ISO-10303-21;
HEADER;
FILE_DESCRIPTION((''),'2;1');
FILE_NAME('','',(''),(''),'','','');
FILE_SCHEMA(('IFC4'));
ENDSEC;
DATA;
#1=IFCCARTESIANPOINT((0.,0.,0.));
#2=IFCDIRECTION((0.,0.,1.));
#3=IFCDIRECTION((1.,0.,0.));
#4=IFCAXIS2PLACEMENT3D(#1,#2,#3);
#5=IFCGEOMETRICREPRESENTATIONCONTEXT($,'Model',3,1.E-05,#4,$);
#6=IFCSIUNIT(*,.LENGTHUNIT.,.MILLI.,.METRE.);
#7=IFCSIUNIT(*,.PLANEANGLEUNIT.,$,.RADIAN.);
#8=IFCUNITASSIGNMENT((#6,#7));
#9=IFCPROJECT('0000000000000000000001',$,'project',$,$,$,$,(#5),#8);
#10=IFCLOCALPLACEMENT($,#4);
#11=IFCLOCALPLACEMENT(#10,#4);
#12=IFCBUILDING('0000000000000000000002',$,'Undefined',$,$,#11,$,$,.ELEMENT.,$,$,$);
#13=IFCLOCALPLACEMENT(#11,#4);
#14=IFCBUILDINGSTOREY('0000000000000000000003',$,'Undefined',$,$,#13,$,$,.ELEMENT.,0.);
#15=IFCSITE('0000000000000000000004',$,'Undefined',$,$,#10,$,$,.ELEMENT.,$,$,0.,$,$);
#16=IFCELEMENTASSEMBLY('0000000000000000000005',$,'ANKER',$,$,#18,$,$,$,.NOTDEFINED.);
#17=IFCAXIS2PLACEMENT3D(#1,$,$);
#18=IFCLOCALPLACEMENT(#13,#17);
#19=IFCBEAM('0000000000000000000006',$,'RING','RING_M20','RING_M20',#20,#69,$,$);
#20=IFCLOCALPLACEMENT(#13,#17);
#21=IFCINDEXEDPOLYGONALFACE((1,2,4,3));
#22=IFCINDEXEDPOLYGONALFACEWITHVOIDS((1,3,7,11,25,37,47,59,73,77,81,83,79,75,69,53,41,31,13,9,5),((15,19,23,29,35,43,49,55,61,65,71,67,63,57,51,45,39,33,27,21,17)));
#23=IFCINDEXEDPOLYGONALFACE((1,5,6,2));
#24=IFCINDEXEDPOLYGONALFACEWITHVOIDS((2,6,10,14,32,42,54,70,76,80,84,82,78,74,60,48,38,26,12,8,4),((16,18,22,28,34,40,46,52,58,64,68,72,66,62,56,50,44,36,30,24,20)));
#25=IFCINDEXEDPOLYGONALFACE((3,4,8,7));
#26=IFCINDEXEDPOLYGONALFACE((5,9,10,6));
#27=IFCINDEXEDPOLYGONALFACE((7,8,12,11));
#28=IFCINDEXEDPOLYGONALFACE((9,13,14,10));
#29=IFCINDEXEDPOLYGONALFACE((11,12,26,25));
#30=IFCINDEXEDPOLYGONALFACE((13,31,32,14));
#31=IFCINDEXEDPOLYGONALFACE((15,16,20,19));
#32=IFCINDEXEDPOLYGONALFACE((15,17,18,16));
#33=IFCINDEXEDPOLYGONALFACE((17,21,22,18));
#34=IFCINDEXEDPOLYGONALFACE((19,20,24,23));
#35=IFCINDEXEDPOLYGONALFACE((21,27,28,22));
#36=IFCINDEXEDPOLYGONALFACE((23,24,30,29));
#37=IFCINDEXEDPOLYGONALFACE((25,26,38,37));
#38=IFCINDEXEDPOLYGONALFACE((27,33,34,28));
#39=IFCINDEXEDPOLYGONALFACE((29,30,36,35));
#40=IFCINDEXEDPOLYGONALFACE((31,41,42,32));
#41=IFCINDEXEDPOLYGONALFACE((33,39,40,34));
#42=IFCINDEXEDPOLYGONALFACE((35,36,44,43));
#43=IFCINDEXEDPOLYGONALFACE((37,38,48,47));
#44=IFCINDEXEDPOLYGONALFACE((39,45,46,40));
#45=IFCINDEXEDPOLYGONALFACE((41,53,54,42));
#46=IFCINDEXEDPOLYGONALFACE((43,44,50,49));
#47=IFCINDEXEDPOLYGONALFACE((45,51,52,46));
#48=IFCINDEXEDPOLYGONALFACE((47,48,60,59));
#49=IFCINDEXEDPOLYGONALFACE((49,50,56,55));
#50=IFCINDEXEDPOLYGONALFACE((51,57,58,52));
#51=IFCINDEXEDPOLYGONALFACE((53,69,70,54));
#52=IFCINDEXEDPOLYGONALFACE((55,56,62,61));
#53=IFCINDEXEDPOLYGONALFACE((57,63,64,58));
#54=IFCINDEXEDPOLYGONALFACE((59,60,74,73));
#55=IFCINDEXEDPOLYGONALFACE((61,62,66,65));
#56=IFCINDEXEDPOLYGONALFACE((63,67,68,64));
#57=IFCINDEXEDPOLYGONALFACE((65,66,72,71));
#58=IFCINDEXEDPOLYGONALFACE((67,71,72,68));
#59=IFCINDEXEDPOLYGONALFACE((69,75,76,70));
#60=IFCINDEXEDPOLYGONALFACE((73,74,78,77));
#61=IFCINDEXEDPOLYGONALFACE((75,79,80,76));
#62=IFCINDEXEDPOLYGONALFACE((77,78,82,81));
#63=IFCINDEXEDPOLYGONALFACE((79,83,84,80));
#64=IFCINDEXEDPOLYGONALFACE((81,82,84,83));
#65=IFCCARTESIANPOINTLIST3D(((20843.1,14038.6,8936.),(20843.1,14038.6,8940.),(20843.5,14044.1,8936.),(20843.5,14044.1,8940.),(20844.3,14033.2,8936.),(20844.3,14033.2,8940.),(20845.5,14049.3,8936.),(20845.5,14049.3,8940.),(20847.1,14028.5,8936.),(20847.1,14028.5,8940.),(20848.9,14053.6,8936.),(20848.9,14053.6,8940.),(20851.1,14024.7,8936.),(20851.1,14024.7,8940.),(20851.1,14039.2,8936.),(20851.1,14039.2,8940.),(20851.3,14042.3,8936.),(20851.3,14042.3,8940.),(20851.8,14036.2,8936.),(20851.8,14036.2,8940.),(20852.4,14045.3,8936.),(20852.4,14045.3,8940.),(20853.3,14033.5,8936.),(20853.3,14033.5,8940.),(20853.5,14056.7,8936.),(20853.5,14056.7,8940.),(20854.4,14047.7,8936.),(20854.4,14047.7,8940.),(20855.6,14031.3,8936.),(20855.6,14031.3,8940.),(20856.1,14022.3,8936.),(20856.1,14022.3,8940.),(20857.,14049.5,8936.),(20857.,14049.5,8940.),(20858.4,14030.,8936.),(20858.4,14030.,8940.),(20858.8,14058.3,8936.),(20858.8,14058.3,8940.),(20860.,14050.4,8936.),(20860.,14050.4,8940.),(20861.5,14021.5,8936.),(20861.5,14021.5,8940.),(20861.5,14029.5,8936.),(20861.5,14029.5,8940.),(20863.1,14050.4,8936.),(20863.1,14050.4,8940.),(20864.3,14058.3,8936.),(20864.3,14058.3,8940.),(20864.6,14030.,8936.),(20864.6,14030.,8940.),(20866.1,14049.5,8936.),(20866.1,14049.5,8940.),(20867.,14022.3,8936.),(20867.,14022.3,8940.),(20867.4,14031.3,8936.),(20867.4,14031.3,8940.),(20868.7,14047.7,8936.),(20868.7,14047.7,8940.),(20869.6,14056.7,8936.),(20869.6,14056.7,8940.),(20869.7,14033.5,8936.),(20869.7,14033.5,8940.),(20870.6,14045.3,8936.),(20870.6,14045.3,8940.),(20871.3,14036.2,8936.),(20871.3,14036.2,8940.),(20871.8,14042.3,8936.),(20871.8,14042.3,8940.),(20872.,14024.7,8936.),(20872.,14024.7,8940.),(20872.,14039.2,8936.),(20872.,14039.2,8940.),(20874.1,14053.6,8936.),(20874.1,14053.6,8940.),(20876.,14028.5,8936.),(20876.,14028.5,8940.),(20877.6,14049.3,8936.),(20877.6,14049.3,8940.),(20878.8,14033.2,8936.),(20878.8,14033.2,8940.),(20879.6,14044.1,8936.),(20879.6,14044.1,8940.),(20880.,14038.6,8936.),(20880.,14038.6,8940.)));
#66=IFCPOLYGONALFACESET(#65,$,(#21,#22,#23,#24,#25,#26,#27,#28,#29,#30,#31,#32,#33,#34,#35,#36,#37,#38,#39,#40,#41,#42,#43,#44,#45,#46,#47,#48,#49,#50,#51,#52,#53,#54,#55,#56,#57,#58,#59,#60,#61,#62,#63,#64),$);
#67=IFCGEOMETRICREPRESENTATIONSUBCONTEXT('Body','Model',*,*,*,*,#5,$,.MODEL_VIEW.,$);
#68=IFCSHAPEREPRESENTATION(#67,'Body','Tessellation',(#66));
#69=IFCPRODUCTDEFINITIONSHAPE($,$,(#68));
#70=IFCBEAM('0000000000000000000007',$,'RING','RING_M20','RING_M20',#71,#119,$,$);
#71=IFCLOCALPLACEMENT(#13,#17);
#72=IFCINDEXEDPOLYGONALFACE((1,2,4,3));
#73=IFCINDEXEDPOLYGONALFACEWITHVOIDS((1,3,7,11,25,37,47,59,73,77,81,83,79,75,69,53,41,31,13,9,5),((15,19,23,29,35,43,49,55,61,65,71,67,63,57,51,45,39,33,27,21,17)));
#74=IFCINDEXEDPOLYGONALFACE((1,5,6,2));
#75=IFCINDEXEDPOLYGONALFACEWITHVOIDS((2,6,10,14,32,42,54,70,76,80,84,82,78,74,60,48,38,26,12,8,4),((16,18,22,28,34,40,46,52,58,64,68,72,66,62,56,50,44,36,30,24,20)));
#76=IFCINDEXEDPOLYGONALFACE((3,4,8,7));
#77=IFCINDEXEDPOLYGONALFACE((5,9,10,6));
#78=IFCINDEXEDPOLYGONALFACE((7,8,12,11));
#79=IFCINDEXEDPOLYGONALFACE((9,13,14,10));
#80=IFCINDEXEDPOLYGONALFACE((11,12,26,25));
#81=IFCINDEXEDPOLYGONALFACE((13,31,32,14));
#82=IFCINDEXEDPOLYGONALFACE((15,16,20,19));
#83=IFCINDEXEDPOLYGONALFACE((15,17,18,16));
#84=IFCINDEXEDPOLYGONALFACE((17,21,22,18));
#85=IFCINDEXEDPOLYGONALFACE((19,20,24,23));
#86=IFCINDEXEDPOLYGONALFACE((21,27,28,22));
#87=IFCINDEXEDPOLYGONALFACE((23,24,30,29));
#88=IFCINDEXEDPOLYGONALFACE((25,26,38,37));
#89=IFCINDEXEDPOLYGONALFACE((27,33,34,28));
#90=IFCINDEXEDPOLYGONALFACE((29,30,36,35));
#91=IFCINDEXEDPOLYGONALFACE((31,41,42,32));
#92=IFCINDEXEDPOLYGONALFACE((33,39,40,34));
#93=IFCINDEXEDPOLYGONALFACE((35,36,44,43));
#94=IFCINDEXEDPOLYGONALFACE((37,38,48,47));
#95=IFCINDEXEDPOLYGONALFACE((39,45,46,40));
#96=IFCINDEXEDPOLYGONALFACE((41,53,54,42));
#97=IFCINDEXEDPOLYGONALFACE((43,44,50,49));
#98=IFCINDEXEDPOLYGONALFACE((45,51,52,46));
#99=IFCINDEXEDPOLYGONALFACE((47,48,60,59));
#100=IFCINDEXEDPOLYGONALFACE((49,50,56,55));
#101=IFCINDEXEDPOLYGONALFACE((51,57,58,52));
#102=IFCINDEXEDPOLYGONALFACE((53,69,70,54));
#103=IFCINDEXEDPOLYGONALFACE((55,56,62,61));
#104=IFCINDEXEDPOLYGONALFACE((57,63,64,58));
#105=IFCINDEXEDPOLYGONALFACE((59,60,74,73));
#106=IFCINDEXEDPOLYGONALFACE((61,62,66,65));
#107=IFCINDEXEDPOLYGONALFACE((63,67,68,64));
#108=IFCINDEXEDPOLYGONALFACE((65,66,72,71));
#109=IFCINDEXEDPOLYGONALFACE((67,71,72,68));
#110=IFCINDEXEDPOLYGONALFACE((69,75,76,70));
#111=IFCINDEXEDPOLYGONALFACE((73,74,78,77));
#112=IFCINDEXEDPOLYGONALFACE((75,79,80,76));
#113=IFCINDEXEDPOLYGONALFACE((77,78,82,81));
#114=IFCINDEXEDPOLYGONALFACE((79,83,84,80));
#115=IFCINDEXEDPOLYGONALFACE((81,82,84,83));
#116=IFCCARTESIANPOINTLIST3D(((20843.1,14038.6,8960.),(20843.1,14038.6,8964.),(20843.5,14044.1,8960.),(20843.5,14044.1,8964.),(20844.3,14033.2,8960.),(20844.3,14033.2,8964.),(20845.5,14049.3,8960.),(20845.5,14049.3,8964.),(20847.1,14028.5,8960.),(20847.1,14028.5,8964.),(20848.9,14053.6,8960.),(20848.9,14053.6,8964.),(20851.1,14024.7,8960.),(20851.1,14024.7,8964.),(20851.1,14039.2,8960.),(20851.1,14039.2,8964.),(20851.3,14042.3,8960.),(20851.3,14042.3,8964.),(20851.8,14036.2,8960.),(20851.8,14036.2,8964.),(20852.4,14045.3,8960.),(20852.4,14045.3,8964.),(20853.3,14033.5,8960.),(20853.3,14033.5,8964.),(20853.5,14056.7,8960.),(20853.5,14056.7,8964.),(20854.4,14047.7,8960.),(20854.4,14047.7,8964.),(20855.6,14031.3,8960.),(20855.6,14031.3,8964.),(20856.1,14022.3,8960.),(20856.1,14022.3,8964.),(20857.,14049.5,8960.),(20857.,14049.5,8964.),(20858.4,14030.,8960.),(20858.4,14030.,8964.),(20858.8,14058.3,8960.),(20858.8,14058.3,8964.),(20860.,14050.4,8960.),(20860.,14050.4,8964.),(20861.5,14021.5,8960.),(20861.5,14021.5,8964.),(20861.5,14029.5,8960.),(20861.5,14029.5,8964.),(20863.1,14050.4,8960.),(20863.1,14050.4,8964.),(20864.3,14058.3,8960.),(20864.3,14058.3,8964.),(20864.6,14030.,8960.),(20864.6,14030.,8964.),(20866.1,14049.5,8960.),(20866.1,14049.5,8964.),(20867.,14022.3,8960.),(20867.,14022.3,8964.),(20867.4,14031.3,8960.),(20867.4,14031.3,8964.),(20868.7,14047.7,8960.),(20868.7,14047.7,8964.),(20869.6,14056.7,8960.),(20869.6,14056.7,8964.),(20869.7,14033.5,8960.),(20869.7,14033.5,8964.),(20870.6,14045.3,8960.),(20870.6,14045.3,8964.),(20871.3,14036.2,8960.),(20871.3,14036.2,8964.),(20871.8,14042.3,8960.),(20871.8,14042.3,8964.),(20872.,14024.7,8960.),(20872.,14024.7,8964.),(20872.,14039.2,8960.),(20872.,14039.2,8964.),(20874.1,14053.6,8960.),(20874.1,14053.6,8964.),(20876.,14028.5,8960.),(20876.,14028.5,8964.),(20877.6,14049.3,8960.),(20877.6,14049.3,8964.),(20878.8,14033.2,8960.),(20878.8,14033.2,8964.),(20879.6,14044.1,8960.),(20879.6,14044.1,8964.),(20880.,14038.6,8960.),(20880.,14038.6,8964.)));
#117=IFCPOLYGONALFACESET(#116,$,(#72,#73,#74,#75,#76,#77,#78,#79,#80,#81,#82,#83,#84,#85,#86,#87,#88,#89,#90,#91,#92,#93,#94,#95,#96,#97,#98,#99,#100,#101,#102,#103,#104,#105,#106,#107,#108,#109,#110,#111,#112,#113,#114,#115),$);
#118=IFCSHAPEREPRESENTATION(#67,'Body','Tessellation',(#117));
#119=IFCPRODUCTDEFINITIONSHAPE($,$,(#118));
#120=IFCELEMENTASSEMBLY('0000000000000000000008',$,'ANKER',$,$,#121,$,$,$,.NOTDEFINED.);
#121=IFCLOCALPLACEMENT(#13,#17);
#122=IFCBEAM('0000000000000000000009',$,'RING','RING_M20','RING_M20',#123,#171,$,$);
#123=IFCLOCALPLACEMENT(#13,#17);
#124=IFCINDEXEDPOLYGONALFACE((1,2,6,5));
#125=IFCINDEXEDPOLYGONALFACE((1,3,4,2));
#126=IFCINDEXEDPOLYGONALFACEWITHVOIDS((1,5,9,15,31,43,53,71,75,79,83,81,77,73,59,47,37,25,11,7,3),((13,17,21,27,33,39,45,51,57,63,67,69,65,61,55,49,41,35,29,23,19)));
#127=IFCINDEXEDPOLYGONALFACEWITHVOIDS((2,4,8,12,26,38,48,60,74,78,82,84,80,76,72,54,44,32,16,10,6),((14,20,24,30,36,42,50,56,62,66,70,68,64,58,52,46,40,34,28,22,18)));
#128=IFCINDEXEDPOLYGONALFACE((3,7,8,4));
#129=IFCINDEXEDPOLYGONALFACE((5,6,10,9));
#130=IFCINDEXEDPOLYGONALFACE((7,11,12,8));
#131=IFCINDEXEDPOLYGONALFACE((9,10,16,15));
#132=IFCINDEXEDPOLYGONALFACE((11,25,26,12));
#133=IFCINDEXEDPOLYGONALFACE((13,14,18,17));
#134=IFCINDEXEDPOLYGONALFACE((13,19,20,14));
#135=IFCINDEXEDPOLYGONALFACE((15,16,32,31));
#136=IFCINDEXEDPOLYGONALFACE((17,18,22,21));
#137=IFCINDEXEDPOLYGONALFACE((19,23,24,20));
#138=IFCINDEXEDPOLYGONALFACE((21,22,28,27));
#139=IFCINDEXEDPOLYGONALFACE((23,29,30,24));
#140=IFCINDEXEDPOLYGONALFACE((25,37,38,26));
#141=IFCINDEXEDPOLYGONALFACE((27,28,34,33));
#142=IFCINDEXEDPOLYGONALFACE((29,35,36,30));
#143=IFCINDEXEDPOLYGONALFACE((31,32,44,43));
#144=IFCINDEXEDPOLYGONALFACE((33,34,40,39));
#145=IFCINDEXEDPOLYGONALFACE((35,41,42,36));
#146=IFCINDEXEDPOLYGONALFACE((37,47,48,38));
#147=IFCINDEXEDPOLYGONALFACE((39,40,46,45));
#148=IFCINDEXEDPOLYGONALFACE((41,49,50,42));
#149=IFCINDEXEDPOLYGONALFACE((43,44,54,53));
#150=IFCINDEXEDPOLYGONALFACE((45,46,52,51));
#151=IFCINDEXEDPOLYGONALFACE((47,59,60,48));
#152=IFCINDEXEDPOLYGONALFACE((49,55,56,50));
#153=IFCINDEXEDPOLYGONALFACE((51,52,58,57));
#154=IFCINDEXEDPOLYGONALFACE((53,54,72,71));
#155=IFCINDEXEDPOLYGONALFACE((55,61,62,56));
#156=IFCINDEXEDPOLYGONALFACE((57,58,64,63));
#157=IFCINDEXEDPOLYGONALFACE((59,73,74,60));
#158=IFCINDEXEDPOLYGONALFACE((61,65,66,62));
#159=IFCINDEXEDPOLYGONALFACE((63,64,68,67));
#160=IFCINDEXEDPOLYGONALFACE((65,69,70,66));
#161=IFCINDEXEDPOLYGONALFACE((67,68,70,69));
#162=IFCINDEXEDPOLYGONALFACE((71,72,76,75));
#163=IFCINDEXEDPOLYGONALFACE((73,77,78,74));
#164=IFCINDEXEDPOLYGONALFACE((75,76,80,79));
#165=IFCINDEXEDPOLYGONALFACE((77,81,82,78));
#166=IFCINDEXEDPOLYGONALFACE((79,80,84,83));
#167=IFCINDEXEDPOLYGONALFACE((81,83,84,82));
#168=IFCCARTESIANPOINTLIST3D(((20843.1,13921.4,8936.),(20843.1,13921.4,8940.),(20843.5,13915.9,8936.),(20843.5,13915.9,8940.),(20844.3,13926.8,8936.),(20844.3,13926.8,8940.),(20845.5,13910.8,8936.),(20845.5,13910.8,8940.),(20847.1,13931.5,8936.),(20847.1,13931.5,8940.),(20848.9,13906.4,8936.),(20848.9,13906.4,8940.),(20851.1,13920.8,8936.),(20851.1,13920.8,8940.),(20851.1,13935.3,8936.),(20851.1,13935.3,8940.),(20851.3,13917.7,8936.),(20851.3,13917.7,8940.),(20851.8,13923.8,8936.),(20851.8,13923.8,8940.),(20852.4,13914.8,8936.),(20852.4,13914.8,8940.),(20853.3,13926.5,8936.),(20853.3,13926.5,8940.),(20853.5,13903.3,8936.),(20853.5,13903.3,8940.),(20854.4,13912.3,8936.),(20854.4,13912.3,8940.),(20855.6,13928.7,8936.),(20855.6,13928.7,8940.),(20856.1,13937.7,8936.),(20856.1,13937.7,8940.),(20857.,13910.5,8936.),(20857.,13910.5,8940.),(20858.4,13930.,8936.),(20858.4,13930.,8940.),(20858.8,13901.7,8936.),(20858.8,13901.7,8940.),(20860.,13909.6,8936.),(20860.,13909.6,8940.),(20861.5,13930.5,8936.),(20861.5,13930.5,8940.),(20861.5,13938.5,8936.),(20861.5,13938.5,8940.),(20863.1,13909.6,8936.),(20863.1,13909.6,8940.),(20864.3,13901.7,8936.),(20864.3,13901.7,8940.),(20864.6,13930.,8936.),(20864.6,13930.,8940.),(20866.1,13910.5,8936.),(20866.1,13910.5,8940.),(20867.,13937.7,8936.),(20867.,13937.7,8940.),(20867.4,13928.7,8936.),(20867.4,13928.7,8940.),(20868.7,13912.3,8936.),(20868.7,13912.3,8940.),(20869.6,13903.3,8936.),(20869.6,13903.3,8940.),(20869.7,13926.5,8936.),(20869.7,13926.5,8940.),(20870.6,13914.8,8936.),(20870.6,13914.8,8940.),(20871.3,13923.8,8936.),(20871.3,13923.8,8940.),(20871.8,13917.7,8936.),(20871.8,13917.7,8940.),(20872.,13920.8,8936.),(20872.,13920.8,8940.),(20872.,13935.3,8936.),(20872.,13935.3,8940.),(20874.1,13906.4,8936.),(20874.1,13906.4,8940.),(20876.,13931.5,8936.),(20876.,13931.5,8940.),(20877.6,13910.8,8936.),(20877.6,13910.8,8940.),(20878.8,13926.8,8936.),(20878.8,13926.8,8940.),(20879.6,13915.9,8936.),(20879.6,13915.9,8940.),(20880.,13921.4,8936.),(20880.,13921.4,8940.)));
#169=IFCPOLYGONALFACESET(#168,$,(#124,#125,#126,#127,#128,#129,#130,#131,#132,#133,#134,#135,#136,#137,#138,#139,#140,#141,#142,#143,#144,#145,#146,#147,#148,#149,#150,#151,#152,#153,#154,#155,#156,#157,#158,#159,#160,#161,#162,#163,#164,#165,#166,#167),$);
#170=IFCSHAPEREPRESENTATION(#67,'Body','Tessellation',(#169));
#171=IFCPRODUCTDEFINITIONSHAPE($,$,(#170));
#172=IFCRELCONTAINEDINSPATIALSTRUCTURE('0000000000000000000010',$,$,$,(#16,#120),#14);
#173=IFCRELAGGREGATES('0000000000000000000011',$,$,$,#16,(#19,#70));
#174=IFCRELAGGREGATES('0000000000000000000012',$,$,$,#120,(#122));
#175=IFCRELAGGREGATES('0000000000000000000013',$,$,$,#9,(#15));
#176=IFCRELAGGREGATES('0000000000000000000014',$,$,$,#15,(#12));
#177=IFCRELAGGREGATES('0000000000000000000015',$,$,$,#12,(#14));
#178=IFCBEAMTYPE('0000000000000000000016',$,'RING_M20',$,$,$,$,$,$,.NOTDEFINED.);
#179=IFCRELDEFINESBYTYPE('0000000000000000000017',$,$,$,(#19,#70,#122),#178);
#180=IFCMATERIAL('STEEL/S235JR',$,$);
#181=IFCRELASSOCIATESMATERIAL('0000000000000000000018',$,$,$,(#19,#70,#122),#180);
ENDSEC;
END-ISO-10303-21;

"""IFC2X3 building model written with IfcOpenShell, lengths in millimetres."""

from ifc_helpers import new_model, si_unit, frame, origin_with_axes, origin_2d_with_axis, place, context, subcontext, project, spatial, hollow_circle, extrude, material, type_object, element, aggregate, save


model = new_model("IFC2X3")

# Units and contexts
model_context = context("Model", 3, precision=1e-05, world=origin_with_axes())
body_context = subcontext(model_context, "Body", "Model", "MODEL_VIEW")
ifc_project = project(units=[si_unit("LENGTHUNIT", "METRE", prefix="MILLI"), si_unit("PLANEANGLEUNIT", "RADIAN")], contexts=[model_context])

# Site, building, storey
site_placement = place(None, origin_with_axes())
site = spatial("IfcSite", under=ifc_project, at=site_placement, Name="Undefined", CompositionType="ELEMENT", RefElevation=0.0)
building_placement = place(site_placement, origin_with_axes())
building = spatial("IfcBuilding", under=site, at=building_placement, Name="Undefined", CompositionType="ELEMENT")
storey_placement = place(building_placement, origin_with_axes())
storey = spatial("IfcBuildingStorey", under=building, at=storey_placement, Name="Undefined", CompositionType="ELEMENT", Elevation=0.0)

# Shared definitions
ifc_material = material(Name="STEEL/S235JR")

# Element assemblies, beams
beam_type_1 = type_object("IfcBeamType", Name="RING_M20", PredefinedType="NOTDEFINED")
assembly_1_placement = place(storey_placement, frame((20861.5, 14040.0, 9010.0), z_axis=(0.0, 1.0, 0.0), x_axis=(0.0, 0.0, -1.0)))
assembly_1 = element("IfcElementAssembly", 1, at=assembly_1_placement, inside=storey, Name="ANKER", PredefinedType="NOTDEFINED")
beam_1_placement = place(storey_placement, frame((20861.5, 14040.0, 8940.0), z_axis=(1.0, 0.0, 0.0), x_axis=(0.0, 0.0, -1.0)))
beam_1 = element("IfcBeam", 2, at=beam_1_placement, type_object=beam_type_1, material=ifc_material, Name="RING", Description="RING_M20", ObjectType="RING_M20", context=body_context, shape_type="SweptSolid", body=[
    extrude(hollow_circle(Radius=18.5, WallThickness=8.0, at=origin_2d_with_axis()), frame((4.0, 0.0, 0.0), z_axis=(-1.0, 0.0, 0.0), x_axis=(0.0, -1.0, 0.0)), (0.0, 0.0, 1.0), 4.0),
])
beam_2_placement = place(storey_placement, frame((20861.5, 14040.0, 8964.0), z_axis=(1.0, 0.0, 0.0), x_axis=(0.0, 0.0, -1.0)))
beam_2 = element("IfcBeam", 3, at=beam_2_placement, type_object=beam_type_1, material=ifc_material, Name="RING", Description="RING_M20", ObjectType="RING_M20", context=body_context, shape_type="SweptSolid", body=[
    extrude(hollow_circle(Radius=18.5, WallThickness=8.0, at=origin_2d_with_axis()), frame((4.0, 0.0, 0.0), z_axis=(-1.0, 0.0, 0.0), x_axis=(0.0, -1.0, 0.0)), (0.0, 0.0, 1.0), 4.0),
])
aggregate(assembly_1, [beam_1, beam_2])
assembly_2_placement = place(storey_placement, frame((20861.5, 13920.0, 9010.0), z_axis=(0.0, 1.0, 0.0), x_axis=(0.0, 0.0, -1.0)))
assembly_2 = element("IfcElementAssembly", 4, at=assembly_2_placement, inside=storey, Name="ANKER", PredefinedType="NOTDEFINED")
beam_3_placement = place(storey_placement, frame((20861.5, 13920.0, 8940.0), z_axis=(-1.0, 0.0, 0.0), x_axis=(0.0, 0.0, -1.0)))
beam_3 = element("IfcBeam", 5, at=beam_3_placement, type_object=beam_type_1, material=ifc_material, Name="RING", Description="RING_M20", ObjectType="RING_M20", context=body_context, shape_type="SweptSolid", body=[
    extrude(hollow_circle(Radius=18.5, WallThickness=8.0, at=origin_2d_with_axis()), frame((4.0, 0.0, 0.0), z_axis=(-1.0, 0.0, 0.0), x_axis=(0.0, -1.0, 0.0)), (0.0, 0.0, 1.0), 4.0),
])
aggregate(assembly_2, [beam_3])

save(model, "model.ifc")
